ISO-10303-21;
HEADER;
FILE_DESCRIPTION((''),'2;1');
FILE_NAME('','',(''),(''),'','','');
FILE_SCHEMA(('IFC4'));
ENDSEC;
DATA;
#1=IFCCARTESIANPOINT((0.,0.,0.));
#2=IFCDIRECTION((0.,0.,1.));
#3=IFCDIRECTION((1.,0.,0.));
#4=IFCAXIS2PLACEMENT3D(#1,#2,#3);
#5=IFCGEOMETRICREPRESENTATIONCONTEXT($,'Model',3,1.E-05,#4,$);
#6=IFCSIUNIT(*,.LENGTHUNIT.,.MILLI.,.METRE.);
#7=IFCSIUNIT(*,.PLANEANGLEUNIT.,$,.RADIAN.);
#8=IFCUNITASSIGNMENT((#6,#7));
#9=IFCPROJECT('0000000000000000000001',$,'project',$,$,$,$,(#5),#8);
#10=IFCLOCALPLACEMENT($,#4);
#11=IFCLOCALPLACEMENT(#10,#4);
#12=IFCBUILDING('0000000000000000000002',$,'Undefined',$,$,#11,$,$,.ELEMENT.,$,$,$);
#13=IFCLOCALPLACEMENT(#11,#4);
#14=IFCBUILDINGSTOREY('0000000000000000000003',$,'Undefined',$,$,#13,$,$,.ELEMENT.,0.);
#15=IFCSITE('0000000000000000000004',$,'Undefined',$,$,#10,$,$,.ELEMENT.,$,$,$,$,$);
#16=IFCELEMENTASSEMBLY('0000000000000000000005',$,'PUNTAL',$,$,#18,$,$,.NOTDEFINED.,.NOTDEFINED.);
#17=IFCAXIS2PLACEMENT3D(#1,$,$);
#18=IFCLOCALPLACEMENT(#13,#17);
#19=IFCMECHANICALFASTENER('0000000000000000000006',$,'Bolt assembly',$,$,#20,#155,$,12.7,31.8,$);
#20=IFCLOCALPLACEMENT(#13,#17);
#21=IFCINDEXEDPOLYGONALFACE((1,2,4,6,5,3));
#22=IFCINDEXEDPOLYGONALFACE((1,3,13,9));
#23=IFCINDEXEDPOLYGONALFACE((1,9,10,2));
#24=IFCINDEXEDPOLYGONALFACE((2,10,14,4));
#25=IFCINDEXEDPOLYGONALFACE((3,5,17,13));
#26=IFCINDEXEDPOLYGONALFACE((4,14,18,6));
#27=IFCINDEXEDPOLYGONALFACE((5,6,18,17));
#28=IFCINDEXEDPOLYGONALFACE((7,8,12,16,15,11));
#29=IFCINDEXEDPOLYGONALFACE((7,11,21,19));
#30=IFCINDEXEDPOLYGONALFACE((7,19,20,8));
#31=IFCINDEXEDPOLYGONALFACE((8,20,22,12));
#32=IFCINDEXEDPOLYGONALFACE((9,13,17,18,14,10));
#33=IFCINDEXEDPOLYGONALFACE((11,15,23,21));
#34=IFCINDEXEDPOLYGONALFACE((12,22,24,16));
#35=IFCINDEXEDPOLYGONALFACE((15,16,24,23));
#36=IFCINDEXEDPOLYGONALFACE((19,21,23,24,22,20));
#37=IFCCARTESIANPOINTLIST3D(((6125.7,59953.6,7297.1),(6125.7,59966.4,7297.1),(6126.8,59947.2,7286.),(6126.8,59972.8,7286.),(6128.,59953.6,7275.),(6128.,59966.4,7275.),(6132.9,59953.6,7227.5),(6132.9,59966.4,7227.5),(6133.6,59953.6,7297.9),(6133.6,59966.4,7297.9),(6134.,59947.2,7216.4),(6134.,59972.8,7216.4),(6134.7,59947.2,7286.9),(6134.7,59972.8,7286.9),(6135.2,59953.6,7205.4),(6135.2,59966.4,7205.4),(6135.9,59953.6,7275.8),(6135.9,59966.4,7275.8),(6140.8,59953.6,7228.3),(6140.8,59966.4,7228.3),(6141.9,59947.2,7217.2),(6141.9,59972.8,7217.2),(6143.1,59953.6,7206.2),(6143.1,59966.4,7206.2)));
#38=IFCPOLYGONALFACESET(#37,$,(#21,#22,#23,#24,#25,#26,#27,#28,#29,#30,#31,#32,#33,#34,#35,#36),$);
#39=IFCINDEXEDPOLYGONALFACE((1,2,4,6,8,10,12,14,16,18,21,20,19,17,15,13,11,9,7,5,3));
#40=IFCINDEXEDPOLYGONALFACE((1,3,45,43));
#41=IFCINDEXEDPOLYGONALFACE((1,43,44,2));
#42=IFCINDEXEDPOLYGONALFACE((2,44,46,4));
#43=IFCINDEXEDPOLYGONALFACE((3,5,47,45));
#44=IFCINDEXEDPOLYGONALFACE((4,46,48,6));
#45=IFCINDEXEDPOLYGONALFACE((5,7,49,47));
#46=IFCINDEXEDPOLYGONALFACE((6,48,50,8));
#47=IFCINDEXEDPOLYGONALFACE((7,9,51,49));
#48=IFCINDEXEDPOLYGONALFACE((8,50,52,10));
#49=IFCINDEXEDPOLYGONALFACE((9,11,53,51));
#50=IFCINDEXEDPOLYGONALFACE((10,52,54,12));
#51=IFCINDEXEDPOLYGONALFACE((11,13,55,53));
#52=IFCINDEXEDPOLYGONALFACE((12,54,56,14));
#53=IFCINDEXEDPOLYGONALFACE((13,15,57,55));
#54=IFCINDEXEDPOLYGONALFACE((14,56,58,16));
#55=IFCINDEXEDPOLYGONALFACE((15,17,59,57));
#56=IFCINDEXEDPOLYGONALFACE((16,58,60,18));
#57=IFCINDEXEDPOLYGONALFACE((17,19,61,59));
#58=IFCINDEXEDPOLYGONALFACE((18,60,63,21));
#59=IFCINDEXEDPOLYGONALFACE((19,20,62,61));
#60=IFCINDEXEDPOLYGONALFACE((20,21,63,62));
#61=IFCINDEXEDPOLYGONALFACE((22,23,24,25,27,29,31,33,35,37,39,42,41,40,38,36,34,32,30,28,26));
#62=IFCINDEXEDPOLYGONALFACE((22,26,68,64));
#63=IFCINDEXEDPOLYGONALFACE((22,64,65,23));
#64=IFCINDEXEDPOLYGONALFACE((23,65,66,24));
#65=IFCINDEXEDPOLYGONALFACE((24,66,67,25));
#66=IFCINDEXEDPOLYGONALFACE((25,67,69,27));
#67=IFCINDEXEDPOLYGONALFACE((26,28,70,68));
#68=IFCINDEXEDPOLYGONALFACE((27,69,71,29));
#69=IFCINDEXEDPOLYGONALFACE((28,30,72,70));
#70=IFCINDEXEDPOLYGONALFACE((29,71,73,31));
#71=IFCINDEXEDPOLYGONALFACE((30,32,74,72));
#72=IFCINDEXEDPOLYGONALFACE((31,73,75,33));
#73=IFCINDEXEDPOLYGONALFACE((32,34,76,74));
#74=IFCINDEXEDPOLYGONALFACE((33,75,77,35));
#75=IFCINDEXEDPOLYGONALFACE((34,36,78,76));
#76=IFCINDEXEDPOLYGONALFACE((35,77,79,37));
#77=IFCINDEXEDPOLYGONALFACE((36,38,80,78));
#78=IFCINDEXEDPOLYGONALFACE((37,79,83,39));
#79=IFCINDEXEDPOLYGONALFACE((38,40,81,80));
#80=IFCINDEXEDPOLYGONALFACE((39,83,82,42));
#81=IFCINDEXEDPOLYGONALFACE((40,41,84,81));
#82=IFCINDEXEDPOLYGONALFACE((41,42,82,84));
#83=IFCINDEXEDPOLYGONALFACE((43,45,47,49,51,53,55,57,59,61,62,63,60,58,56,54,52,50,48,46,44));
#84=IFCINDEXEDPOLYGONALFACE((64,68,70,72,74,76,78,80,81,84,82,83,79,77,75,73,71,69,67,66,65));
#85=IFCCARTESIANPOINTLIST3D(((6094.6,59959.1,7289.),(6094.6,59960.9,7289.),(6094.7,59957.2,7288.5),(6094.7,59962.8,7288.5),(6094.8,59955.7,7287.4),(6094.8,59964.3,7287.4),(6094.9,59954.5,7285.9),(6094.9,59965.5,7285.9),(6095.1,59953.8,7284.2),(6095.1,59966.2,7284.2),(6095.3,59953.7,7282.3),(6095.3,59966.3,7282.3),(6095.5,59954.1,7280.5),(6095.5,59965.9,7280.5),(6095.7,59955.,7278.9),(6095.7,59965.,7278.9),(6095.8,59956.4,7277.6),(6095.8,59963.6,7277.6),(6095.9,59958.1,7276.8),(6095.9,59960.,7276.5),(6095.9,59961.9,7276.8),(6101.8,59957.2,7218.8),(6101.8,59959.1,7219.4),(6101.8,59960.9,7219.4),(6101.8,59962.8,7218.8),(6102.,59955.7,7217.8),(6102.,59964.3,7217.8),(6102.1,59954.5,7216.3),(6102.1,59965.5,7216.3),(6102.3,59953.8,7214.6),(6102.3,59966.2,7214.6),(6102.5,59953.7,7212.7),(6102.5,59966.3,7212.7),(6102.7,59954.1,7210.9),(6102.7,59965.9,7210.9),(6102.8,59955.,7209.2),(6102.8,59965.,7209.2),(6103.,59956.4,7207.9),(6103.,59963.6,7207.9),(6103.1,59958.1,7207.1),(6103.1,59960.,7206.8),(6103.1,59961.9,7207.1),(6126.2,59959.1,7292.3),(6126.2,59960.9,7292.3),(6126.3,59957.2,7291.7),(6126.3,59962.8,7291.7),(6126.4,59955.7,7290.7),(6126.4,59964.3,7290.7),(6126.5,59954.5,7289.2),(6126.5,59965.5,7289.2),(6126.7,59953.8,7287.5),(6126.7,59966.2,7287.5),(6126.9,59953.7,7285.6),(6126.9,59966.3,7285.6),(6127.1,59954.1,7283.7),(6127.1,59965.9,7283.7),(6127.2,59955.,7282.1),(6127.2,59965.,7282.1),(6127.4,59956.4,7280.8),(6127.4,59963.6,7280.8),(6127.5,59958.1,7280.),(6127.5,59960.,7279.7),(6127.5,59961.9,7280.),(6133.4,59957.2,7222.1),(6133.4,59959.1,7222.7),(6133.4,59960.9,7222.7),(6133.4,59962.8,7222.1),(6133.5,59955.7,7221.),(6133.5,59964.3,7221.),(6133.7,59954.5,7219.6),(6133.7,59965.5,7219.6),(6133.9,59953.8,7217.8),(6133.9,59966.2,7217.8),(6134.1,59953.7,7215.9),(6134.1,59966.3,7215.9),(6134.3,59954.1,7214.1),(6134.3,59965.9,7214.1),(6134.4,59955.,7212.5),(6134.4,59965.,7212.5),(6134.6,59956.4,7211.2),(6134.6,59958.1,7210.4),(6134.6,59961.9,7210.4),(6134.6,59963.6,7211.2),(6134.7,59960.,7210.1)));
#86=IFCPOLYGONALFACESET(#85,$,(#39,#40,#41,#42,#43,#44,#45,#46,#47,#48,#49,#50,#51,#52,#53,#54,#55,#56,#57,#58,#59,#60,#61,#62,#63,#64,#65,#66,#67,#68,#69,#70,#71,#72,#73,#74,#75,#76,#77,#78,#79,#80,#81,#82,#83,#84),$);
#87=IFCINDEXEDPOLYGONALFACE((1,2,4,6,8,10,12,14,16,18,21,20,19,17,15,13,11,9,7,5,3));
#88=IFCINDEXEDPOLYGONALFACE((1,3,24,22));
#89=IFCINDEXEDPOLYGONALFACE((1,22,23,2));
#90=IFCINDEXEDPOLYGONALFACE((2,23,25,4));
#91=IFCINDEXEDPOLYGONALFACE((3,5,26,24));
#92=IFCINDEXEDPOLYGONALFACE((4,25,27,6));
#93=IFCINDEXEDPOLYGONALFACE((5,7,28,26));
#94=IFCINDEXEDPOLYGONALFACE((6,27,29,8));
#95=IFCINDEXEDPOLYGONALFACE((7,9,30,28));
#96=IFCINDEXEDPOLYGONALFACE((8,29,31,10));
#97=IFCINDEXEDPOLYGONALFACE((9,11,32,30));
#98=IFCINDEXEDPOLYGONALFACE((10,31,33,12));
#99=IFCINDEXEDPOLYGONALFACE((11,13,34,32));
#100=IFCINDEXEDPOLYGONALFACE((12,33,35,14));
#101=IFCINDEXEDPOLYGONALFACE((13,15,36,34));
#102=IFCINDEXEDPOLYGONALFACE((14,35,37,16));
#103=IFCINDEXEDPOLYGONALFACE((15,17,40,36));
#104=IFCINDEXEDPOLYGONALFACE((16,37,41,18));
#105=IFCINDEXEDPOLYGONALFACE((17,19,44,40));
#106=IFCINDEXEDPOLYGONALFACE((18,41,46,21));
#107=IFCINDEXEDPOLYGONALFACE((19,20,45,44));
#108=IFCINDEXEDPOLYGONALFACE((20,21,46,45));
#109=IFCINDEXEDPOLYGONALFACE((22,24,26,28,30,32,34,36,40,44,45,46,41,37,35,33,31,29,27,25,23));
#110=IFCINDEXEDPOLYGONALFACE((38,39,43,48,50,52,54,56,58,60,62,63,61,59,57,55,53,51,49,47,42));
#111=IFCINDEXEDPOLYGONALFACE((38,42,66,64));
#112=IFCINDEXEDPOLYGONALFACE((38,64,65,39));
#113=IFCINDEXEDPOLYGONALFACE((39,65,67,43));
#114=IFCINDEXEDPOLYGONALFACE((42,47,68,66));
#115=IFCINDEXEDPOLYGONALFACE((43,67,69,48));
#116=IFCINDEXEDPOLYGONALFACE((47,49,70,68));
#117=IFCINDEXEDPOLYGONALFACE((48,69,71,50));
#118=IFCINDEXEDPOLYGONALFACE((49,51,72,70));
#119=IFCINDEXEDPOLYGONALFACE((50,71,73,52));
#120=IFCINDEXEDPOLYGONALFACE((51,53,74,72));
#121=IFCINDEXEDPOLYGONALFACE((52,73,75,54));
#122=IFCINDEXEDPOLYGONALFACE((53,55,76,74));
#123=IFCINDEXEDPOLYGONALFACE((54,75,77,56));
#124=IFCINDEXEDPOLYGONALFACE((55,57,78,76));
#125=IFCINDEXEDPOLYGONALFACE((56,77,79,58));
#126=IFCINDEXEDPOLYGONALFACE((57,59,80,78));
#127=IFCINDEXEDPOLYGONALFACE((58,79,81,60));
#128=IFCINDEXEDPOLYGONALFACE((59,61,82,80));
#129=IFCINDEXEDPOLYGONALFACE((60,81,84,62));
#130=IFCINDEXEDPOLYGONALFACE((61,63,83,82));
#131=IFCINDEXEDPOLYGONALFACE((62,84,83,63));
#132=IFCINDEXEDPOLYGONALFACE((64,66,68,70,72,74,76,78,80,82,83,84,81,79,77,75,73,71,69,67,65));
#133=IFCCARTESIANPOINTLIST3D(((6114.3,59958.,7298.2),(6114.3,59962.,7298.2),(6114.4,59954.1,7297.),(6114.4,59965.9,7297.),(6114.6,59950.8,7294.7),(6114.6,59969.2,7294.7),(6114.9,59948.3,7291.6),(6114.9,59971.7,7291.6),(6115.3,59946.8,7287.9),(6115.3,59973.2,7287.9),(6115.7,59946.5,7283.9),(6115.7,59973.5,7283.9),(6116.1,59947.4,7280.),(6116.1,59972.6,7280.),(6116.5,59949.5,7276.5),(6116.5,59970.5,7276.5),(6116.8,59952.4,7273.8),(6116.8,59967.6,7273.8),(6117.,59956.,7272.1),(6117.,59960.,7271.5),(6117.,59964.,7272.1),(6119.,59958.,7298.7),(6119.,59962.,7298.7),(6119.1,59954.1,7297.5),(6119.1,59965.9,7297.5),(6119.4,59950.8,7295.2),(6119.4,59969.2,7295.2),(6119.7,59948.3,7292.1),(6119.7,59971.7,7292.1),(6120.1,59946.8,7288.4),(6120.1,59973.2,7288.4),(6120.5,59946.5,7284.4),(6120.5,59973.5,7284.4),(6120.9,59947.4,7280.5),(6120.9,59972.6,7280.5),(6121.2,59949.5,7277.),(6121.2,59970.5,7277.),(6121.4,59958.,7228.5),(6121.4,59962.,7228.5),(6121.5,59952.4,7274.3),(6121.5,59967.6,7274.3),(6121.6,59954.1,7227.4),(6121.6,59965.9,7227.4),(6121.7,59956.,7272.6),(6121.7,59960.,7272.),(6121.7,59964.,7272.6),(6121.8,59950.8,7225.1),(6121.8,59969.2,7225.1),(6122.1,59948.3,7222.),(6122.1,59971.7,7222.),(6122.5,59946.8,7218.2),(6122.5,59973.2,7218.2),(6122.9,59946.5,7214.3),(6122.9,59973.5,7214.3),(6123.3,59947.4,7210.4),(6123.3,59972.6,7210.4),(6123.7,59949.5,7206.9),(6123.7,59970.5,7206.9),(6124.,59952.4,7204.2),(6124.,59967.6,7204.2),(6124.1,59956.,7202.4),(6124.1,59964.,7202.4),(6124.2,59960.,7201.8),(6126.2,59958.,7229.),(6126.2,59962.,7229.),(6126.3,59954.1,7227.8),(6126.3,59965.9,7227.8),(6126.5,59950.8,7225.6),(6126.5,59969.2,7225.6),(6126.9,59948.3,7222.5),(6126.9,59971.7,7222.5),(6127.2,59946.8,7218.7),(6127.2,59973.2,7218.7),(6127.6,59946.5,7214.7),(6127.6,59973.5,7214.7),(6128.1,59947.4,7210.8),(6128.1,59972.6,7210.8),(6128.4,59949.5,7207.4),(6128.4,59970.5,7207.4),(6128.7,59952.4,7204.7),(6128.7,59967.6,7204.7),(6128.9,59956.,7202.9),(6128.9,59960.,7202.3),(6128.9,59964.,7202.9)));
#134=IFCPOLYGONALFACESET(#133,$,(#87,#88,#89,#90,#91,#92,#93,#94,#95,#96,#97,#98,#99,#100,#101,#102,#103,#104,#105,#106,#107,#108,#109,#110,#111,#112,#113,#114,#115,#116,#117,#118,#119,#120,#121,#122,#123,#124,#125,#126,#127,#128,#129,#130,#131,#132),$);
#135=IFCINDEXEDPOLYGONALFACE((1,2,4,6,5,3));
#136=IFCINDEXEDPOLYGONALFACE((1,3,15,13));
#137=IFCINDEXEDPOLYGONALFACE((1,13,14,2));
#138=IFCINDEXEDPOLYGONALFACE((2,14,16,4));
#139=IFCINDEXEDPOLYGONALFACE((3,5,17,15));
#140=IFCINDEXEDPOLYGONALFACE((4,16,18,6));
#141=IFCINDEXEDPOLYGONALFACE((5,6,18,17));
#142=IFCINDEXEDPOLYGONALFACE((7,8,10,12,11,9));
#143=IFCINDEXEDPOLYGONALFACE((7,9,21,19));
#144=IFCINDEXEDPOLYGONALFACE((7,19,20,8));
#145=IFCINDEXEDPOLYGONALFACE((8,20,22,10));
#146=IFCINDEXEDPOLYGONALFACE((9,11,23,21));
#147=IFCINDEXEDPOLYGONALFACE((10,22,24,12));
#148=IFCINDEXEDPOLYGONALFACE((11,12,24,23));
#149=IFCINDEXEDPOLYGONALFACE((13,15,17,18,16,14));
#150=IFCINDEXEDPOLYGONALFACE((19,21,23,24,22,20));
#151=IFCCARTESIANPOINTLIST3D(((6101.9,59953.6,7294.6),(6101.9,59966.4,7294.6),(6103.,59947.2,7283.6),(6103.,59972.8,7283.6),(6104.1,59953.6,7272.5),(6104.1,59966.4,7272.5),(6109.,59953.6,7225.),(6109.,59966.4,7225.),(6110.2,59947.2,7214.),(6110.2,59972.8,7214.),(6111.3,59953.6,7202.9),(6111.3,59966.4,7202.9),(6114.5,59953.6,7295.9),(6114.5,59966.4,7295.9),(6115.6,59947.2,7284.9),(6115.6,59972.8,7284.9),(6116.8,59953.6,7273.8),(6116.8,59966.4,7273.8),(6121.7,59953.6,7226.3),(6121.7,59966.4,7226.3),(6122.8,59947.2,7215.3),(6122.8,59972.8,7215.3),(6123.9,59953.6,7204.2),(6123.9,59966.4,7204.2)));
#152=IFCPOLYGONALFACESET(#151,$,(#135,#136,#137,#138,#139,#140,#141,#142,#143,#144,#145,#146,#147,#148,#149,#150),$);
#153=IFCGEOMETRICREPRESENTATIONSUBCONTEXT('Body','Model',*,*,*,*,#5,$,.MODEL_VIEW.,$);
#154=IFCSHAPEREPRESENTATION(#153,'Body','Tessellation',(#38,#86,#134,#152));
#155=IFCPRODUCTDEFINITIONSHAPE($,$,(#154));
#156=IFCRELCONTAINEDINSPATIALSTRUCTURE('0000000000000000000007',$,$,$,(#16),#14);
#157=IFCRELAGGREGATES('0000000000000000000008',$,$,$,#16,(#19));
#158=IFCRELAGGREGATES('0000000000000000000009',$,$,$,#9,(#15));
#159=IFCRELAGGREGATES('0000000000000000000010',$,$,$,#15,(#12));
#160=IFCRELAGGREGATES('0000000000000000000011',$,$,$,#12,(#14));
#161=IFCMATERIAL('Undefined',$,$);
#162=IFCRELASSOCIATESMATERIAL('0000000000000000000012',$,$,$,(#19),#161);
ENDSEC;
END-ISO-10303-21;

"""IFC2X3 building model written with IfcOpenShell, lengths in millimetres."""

from ifc_helpers import new_model, si_unit, frame, origin_with_axes, origin_2d_with_axis, place, context, subcontext, project, spatial, polyline, circle, outline, extrude, source, transform, mapped, material, element, aggregate, save


model = new_model("IFC2X3")

# Units and contexts
model_context = context("Model", 3, precision=1e-05, world=origin_with_axes())
body_context = subcontext(model_context, "Body", "Model", "MODEL_VIEW")
ifc_project = project(units=[si_unit("LENGTHUNIT", "METRE", prefix="MILLI"), si_unit("PLANEANGLEUNIT", "RADIAN")], contexts=[model_context])

# Site, building, storey
site_placement = place(None, origin_with_axes())
site = spatial("IfcSite", under=ifc_project, at=site_placement, Name="Undefined", CompositionType="ELEMENT")
building_placement = place(site_placement, origin_with_axes())
building = spatial("IfcBuilding", under=site, at=building_placement, Name="Undefined", CompositionType="ELEMENT")
storey_placement = place(building_placement, origin_with_axes())
storey = spatial("IfcBuildingStorey", under=building, at=storey_placement, Name="Undefined", CompositionType="ELEMENT", Elevation=0.0)

# Element assembly
assembly_1_placement = place(storey_placement, origin_with_axes())
assembly_1 = element("IfcElementAssembly", 1, at=assembly_1_placement, inside=storey, Name="PUNTAL", AssemblyPlace="NOTDEFINED", PredefinedType="NOTDEFINED")

# Mechanical fastener
ifc_material_1 = material(Name="Undefined")
shared_shape_1 = source(origin_with_axes(), body_context, "Body", "SweptSolid", [
    extrude(outline(polyline([(11.1, -6.4), (11.1, 6.4), (0.0, 12.8), (-11.1, 6.4), (-11.1, -6.4), (0.0, -12.8), (11.1, -6.4)])), frame((0.0, -12.4, 0.0), z_axis=(0.0, 1.0, 0.0), x_axis=(1.0, 0.0, 0.0)), (0.0, 0.0, 1.0), 7.9),
    extrude(circle(Radius=6.3, at=origin_2d_with_axis()), frame((0.0, -4.5, 0.0), z_axis=(0.0, 1.0, 0.0), x_axis=(1.0, 0.0, 0.0)), (0.0, 0.0, 1.0), 31.8),
    extrude(circle(Radius=13.5, at=origin_2d_with_axis()), frame((0.0, 2.0, 0.0), z_axis=(0.0, 1.0, 0.0), x_axis=(1.0, 0.0, 0.0)), (0.0, 0.0, 1.0), 4.8),
    extrude(outline(polyline([(11.1, -6.4), (11.1, 6.4), (0.0, 12.8), (-11.1, 6.4), (-11.1, -6.4), (0.0, -12.8), (11.1, -6.4)])), frame((0.0, 6.8, 0.0), z_axis=(0.0, 1.0, 0.0), x_axis=(1.0, 0.0, 0.0)), (0.0, 0.0, 1.0), 12.7),
])
mechanical_fastener_1_placement = place(assembly_1_placement, frame((6122.4, 59960.0, 7285.6), z_axis=(0.0, 1.0, 0.0), x_axis=(0.102562, 0.0, -0.994727)))
mechanical_fastener_1 = element("IfcMechanicalFastener", 2, at=mechanical_fastener_1_placement, material=ifc_material_1, Name="Bolt assembly", NominalDiameter=12.7, NominalLength=31.8, context=body_context, shape_type="MappedRepresentation", body=[
    mapped(shared_shape_1, transform((0.0, 0.0, 0.0))),
    mapped(shared_shape_1, transform((70.0, 0.0, 0.0))),
])
aggregate(assembly_1, [mechanical_fastener_1])

save(model, "model.ifc")
